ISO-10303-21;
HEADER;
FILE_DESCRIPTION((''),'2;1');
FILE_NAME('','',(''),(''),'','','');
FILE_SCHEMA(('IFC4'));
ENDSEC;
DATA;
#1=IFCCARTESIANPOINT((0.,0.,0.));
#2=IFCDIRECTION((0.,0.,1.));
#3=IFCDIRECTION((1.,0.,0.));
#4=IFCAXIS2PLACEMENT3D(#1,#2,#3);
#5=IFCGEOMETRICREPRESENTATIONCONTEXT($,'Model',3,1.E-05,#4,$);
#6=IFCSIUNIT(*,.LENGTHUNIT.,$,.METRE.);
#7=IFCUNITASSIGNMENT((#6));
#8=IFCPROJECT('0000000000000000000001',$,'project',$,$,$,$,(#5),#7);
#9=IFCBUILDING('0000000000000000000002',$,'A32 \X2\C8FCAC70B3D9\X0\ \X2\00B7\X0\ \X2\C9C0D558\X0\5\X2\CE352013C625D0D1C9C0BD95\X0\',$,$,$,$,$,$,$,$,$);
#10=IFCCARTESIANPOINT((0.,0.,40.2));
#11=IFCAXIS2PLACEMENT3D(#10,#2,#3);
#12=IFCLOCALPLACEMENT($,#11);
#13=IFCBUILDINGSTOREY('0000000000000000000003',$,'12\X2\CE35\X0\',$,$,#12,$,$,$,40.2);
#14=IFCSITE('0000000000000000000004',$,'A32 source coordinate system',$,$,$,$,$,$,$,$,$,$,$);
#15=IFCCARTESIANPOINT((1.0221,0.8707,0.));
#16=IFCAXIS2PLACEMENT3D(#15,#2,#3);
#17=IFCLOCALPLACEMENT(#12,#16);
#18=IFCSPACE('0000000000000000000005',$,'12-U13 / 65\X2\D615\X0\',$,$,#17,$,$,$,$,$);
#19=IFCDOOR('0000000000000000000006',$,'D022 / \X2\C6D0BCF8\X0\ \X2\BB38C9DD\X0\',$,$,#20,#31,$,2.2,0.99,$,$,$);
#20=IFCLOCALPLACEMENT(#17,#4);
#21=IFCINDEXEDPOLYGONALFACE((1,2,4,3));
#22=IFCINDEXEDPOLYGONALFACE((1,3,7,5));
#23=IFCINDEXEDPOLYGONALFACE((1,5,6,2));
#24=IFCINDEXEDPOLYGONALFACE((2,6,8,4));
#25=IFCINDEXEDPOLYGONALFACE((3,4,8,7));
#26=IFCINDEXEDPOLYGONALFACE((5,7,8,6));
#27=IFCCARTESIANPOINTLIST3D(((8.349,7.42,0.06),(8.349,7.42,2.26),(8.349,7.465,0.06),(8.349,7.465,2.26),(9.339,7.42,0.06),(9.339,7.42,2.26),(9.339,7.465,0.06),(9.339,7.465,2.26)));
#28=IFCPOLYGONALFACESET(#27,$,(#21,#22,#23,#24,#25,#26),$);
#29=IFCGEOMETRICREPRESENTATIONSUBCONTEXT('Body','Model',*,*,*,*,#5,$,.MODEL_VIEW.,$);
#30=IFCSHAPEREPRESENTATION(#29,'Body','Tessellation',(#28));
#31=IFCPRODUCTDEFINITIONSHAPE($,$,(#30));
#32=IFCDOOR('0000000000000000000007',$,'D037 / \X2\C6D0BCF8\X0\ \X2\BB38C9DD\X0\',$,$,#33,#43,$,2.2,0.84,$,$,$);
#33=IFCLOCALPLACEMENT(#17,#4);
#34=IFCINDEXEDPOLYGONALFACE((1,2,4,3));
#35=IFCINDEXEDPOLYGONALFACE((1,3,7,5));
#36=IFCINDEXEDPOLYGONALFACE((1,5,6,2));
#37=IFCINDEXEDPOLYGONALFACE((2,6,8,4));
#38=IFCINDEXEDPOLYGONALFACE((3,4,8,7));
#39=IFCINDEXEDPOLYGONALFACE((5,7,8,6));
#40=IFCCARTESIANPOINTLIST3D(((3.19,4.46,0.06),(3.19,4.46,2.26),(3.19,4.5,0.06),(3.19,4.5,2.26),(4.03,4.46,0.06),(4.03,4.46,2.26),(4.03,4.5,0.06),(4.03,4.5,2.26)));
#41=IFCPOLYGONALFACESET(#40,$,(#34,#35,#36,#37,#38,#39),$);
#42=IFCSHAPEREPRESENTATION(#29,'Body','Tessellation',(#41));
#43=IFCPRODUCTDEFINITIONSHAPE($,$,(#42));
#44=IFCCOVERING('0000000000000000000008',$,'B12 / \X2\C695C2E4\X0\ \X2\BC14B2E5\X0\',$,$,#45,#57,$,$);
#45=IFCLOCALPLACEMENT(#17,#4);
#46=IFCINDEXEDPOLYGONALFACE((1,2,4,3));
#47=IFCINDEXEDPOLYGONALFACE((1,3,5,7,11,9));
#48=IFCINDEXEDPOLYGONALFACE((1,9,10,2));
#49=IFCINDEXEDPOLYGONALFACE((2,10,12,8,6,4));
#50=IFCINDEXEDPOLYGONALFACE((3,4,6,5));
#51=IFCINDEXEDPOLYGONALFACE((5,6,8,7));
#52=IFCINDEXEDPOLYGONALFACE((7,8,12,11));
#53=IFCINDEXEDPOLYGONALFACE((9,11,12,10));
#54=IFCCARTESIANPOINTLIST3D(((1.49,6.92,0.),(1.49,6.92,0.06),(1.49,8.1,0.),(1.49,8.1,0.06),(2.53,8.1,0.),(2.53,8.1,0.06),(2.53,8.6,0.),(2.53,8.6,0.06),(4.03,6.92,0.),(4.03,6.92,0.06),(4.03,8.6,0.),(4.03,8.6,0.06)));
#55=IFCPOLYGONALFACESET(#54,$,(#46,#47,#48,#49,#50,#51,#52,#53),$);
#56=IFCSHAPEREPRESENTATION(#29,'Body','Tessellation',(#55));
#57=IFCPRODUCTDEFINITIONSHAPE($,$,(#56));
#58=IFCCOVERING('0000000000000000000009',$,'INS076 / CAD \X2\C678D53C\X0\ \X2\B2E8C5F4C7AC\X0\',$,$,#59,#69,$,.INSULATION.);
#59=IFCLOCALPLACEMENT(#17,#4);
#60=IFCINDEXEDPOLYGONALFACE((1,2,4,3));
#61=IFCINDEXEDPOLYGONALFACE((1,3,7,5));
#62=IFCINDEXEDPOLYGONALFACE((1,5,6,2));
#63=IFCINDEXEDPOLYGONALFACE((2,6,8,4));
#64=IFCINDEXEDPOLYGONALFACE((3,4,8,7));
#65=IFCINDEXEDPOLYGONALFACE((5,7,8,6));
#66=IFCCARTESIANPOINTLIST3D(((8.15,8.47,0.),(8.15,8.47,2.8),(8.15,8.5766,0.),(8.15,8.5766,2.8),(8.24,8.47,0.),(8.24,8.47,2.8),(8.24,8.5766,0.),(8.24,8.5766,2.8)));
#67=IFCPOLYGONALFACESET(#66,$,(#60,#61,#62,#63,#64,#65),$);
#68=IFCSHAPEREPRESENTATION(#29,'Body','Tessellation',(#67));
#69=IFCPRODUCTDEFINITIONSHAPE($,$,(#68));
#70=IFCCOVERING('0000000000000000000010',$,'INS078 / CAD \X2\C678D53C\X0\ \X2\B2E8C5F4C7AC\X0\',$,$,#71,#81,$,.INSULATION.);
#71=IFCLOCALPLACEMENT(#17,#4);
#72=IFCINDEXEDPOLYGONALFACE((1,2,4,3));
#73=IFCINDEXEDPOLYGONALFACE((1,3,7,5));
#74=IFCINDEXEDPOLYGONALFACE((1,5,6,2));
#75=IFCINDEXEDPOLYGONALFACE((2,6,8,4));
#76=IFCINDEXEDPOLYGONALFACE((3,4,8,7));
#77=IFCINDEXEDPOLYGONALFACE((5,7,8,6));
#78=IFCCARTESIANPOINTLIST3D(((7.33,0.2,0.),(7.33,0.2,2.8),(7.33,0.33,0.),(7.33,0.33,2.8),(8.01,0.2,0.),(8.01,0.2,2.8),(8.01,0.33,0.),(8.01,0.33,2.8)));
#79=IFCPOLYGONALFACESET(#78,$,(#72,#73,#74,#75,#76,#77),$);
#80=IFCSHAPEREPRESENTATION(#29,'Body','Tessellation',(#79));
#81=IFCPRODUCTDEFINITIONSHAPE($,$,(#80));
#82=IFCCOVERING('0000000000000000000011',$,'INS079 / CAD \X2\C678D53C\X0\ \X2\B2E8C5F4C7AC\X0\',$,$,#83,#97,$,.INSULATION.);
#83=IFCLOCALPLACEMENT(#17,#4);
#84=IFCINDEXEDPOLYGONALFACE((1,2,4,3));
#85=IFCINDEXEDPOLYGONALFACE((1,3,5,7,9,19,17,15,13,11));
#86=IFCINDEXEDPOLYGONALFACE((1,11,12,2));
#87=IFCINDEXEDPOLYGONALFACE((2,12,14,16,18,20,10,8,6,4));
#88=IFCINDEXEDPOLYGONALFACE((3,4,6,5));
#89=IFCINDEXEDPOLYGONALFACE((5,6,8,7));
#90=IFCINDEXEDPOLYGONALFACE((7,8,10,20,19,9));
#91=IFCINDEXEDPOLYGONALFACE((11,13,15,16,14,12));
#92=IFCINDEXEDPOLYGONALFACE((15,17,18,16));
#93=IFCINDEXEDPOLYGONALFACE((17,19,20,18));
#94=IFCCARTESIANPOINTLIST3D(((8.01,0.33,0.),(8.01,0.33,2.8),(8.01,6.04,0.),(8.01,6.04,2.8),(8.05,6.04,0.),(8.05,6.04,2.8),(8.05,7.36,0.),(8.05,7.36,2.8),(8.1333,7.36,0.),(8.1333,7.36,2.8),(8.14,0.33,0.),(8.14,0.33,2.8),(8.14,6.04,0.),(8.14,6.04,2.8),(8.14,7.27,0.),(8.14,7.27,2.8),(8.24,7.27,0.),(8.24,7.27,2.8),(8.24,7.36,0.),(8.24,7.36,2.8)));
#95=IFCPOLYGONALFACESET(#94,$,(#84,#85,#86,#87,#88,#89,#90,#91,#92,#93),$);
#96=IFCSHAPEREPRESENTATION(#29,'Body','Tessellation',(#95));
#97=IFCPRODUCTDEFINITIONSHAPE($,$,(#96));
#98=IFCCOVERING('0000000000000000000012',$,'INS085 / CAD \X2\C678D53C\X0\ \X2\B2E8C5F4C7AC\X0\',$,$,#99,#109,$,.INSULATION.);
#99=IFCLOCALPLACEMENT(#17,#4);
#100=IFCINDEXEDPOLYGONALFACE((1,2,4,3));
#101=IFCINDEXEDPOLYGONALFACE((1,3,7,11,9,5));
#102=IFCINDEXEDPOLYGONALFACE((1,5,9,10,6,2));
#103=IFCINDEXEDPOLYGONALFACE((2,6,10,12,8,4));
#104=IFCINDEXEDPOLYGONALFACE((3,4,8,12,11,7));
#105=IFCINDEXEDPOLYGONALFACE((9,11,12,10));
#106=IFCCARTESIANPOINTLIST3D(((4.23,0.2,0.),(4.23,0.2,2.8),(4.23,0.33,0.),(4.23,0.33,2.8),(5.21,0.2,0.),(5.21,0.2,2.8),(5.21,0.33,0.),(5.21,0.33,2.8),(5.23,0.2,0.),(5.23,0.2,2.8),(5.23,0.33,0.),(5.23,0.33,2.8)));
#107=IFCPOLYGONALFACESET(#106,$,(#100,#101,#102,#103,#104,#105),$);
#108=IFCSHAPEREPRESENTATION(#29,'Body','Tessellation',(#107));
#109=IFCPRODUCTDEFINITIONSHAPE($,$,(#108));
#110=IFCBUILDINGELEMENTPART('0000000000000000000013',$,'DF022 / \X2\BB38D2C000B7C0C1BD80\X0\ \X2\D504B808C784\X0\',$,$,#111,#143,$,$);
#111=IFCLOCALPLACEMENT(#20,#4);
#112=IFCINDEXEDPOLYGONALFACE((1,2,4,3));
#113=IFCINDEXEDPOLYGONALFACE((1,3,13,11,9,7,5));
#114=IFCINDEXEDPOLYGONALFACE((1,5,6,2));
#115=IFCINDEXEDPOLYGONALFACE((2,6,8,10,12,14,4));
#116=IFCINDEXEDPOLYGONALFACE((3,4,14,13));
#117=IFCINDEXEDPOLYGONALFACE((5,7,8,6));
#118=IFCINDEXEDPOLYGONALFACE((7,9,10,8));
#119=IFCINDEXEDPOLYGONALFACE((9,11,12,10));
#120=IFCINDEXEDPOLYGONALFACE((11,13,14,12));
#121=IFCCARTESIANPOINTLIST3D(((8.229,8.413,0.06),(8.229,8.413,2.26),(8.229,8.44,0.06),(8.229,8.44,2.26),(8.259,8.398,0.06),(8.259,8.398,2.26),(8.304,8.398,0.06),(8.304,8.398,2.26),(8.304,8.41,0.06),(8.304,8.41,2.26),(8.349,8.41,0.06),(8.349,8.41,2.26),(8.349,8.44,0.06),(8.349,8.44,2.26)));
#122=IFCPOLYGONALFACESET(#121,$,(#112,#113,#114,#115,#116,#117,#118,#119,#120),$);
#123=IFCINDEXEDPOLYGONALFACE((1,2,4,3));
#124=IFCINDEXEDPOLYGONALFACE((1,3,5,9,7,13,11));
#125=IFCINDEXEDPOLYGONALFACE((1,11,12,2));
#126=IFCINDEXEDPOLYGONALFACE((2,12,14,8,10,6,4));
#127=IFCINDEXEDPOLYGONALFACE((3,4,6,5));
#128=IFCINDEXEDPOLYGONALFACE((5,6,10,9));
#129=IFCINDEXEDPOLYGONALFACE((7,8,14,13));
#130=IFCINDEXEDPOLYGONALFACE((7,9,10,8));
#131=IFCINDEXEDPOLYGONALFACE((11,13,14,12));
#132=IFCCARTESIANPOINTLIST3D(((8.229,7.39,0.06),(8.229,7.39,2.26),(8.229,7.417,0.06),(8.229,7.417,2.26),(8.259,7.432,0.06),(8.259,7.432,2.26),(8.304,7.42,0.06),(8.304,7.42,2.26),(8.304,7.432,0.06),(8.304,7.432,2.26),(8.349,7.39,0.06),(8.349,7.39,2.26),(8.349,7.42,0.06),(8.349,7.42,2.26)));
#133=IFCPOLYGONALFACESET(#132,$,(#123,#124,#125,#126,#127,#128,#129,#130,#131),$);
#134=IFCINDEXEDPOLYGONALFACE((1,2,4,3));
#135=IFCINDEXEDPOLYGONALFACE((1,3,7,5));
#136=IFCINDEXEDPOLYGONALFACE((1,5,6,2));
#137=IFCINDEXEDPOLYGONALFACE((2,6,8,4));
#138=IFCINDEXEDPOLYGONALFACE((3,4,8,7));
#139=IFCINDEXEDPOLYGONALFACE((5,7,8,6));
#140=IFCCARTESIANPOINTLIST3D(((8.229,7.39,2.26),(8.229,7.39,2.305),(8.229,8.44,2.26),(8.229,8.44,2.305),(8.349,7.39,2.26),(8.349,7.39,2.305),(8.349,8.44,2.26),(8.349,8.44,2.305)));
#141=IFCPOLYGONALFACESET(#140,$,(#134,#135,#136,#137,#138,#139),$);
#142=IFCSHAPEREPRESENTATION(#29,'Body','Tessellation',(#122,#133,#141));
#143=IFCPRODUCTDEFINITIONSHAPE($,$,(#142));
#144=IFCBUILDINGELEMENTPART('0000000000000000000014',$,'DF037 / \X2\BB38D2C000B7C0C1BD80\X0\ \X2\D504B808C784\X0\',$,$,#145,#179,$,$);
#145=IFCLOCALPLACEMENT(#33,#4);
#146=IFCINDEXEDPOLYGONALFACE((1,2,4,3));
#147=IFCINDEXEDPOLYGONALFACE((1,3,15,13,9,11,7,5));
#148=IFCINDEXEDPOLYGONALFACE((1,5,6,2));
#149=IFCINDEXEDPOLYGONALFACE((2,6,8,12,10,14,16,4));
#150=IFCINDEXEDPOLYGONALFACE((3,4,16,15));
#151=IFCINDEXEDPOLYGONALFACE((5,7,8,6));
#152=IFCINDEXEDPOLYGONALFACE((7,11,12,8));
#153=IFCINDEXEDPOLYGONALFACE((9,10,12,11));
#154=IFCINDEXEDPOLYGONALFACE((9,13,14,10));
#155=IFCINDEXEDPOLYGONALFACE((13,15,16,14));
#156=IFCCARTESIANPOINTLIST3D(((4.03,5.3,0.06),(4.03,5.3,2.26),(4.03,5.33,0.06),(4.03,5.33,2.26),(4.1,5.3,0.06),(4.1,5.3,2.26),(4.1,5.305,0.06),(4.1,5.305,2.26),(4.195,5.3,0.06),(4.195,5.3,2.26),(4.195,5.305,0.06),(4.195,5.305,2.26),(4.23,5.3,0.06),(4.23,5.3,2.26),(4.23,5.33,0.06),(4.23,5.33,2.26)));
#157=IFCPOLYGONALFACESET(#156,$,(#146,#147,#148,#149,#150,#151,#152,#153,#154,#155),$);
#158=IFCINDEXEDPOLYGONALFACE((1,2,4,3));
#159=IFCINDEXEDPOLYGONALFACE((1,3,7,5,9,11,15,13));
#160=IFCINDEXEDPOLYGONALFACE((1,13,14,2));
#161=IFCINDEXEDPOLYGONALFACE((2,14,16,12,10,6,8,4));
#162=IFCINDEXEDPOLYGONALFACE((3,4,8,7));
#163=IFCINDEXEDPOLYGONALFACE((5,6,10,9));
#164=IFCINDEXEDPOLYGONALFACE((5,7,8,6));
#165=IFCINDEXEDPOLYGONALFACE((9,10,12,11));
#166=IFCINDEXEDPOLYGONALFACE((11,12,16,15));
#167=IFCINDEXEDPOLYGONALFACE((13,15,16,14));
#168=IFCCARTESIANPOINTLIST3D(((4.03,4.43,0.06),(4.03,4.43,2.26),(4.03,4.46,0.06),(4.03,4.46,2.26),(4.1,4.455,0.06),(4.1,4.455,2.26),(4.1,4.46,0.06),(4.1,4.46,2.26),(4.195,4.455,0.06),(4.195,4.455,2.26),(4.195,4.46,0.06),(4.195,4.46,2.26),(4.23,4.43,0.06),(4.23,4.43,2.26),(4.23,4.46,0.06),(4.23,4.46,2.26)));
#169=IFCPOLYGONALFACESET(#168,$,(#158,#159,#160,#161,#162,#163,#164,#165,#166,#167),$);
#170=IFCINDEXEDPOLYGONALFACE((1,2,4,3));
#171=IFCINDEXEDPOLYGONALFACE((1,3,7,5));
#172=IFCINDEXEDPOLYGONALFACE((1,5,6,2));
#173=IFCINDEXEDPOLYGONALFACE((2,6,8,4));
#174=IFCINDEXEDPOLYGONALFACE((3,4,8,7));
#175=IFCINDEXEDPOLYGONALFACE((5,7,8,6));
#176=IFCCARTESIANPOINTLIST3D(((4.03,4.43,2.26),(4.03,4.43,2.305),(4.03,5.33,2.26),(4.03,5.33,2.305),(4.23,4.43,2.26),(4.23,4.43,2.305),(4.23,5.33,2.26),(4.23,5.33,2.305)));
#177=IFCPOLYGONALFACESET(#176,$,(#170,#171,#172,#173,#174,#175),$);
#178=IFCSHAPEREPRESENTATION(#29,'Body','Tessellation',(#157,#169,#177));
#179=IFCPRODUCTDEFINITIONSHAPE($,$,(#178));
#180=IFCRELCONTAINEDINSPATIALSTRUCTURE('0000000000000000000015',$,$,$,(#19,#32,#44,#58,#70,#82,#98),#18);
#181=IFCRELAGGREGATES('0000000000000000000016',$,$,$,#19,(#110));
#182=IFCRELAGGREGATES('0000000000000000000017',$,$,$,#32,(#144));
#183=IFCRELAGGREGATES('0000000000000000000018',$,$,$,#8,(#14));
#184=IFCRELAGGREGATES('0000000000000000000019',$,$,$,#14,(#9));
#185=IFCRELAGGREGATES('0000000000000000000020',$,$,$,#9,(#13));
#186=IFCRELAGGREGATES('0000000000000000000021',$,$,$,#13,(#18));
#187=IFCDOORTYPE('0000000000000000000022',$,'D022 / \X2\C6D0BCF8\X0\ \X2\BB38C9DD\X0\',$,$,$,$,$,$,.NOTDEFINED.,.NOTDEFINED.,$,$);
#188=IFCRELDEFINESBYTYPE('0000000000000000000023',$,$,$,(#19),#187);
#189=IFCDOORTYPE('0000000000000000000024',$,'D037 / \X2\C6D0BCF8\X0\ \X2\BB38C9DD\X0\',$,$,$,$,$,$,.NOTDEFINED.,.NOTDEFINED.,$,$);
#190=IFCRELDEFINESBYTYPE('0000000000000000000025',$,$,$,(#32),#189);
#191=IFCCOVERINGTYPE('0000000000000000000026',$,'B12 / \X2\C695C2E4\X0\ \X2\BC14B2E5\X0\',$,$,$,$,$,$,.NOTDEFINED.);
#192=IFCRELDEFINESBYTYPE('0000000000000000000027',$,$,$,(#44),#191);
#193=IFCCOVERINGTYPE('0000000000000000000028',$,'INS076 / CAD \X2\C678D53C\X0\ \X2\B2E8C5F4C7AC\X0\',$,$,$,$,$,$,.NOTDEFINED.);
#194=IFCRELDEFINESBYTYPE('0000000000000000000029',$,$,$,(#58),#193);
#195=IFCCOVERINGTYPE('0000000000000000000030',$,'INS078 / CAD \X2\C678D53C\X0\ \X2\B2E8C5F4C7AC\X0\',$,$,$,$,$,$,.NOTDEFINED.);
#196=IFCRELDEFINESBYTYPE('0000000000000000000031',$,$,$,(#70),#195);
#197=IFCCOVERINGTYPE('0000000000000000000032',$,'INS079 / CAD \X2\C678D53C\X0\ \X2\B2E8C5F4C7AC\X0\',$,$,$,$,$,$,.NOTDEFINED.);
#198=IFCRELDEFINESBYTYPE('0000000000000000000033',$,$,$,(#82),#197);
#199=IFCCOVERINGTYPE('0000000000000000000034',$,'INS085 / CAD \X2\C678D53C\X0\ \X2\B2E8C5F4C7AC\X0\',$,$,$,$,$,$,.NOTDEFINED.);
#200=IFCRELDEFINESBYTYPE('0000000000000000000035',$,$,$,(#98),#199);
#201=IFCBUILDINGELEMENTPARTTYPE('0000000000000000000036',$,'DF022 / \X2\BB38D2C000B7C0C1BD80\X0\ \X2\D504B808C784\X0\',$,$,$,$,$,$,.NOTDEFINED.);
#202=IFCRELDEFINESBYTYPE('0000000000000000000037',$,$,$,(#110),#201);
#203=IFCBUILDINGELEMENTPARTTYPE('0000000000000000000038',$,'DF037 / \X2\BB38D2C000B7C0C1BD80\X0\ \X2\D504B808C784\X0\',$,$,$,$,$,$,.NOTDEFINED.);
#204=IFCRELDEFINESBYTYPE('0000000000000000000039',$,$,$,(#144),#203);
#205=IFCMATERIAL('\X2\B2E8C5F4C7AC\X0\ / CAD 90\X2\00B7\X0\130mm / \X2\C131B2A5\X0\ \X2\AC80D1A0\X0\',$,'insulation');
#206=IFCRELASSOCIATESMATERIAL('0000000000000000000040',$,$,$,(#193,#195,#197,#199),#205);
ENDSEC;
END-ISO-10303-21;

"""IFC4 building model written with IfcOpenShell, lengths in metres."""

from ifc_helpers import new_model, si_unit, frame, origin, origin_with_axes, place, context, subcontext, project, spatial, polyline, outline, extrude, source, transform, mapped, material, type_object, type_shapes, element, aggregate, save


model = new_model("IFC4")

# Units and contexts
model_context = context("Model", 3, precision=1e-05, world=origin_with_axes())
body_context = subcontext(model_context, "Body", "Model", "MODEL_VIEW")
ifc_project = project(units=[si_unit("LENGTHUNIT", "METRE")], contexts=[model_context])

# Site, building, storey
site = spatial("IfcSite", under=ifc_project, Name="A32 source coordinate system")
building = spatial("IfcBuilding", under=site, Name="A32 주거동 · 지하5층–옥탑지붕")
storey_placement = place(None, frame((0.0, 0.0, 40.2), z_axis=(0.0, 0.0, 1.0), x_axis=(1.0, 0.0, 0.0)))
storey = spatial("IfcBuildingStorey", under=building, at=storey_placement, Name="12층", Elevation=40.2)

# Shared definitions
space_placement = place(storey_placement, frame((1.0221, 0.8707, 0.0), z_axis=(0.0, 0.0, 1.0), x_axis=(1.0, 0.0, 0.0)))
space = spatial("IfcSpace", under=storey, at=space_placement, Name="12-U13 / 65형")

# Doors
door_type_1 = type_object("IfcDoorType", Name="D022 / 원본 문짝", OperationType="NOTDEFINED", PredefinedType="NOTDEFINED")
shared_shape_1 = source(origin(), body_context, "Body", "SweptSolid", [
    extrude(outline(polyline([(9.339, 7.465), (9.339, 7.42), (8.349, 7.42), (8.349, 7.465), (9.339, 7.465)])), frame((0.0, 0.0, 0.06)), (0.0, 0.0, 1.0), 2.2),
])
type_shapes(door_type_1, [shared_shape_1])
door_1_placement = place(space_placement, origin_with_axes())
door_1 = element("IfcDoor", 1, at=door_1_placement, inside=space, type_object=door_type_1, Name="D022 / 원본 문짝", OverallHeight=2.2, OverallWidth=0.99, context=body_context, shape_type="MappedRepresentation", body=[
    mapped(shared_shape_1, transform((0.0, 0.0, 0.0), scale=1.0)),
])
door_type_2 = type_object("IfcDoorType", Name="D037 / 원본 문짝", OperationType="NOTDEFINED", PredefinedType="NOTDEFINED")
shared_shape_2 = source(origin(), body_context, "Body", "SweptSolid", [
    extrude(outline(polyline([(4.03, 4.46), (3.19, 4.46), (3.19, 4.5), (4.03, 4.5), (4.03, 4.46)])), frame((0.0, 0.0, 0.06)), (0.0, 0.0, 1.0), 2.2),
])
type_shapes(door_type_2, [shared_shape_2])
door_2_placement = place(space_placement, origin_with_axes())
door_2 = element("IfcDoor", 2, at=door_2_placement, inside=space, type_object=door_type_2, Name="D037 / 원본 문짝", OverallHeight=2.2, OverallWidth=0.84, context=body_context, shape_type="MappedRepresentation", body=[
    mapped(shared_shape_2, transform((0.0, 0.0, 0.0), scale=1.0)),
])

# Coverings
covering_type_1 = type_object("IfcCoveringType", Name="B12 / 욕실 바닥", PredefinedType="NOTDEFINED")
shared_shape_3 = source(origin(), body_context, "Body", "SweptSolid", [
    extrude(outline(polyline([(2.53, 8.6), (4.03, 8.6), (4.03, 6.92), (1.49, 6.92), (1.49, 8.1), (2.53, 8.1), (2.53, 8.6)])), origin(), (0.0, 0.0, 1.0), 0.06),
])
type_shapes(covering_type_1, [shared_shape_3])
covering_1_placement = place(space_placement, origin_with_axes())
element("IfcCovering", 3, at=covering_1_placement, inside=space, type_object=covering_type_1, Name="B12 / 욕실 바닥", context=body_context, shape_type="MappedRepresentation", body=[
    mapped(shared_shape_3, transform((0.0, 0.0, 0.0), scale=1.0)),
])
ifc_material = material(Name="단열재 / CAD 90·130mm / 성능 검토", Category="insulation")
covering_type_2 = type_object("IfcCoveringType", Name="INS076 / CAD 외피 단열재", PredefinedType="NOTDEFINED", material=ifc_material)
shared_shape_4 = source(origin(), body_context, "Body", "SweptSolid", [
    extrude(outline(polyline([(8.24, 8.5766), (8.24, 8.47), (8.15, 8.47), (8.15, 8.5766), (8.24, 8.5766)])), origin(), (0.0, 0.0, 1.0), 2.8),
])
type_shapes(covering_type_2, [shared_shape_4])
covering_2_placement = place(space_placement, origin_with_axes())
element("IfcCovering", 4, at=covering_2_placement, inside=space, type_object=covering_type_2, Name="INS076 / CAD 외피 단열재", PredefinedType="INSULATION", context=body_context, shape_type="MappedRepresentation", body=[
    mapped(shared_shape_4, transform((0.0, 0.0, 0.0), scale=1.0)),
])
covering_type_3 = type_object("IfcCoveringType", Name="INS078 / CAD 외피 단열재", PredefinedType="NOTDEFINED", material=ifc_material)
shared_shape_5 = source(origin(), body_context, "Body", "SweptSolid", [
    extrude(outline(polyline([(8.01, 0.2), (7.33, 0.2), (7.33, 0.33), (8.01, 0.33), (8.01, 0.2)])), origin(), (0.0, 0.0, 1.0), 2.8),
])
type_shapes(covering_type_3, [shared_shape_5])
covering_3_placement = place(space_placement, origin_with_axes())
element("IfcCovering", 5, at=covering_3_placement, inside=space, type_object=covering_type_3, Name="INS078 / CAD 외피 단열재", PredefinedType="INSULATION", context=body_context, shape_type="MappedRepresentation", body=[
    mapped(shared_shape_5, transform((0.0, 0.0, 0.0), scale=1.0)),
])
covering_type_4 = type_object("IfcCoveringType", Name="INS079 / CAD 외피 단열재", PredefinedType="NOTDEFINED", material=ifc_material)
shared_shape_6 = source(origin(), body_context, "Body", "SweptSolid", [
    extrude(outline(polyline([(8.24, 7.27), (8.14, 7.27), (8.14, 6.04), (8.14, 0.33), (8.01, 0.33), (8.01, 6.04), (8.05, 6.04), (8.05, 7.36), (8.1333, 7.36), (8.24, 7.36), (8.24, 7.27)])), origin(), (0.0, 0.0, 1.0), 2.8),
])
type_shapes(covering_type_4, [shared_shape_6])
covering_4_placement = place(space_placement, origin_with_axes())
element("IfcCovering", 6, at=covering_4_placement, inside=space, type_object=covering_type_4, Name="INS079 / CAD 외피 단열재", PredefinedType="INSULATION", context=body_context, shape_type="MappedRepresentation", body=[
    mapped(shared_shape_6, transform((0.0, 0.0, 0.0), scale=1.0)),
])
covering_type_5 = type_object("IfcCoveringType", Name="INS085 / CAD 외피 단열재", PredefinedType="NOTDEFINED", material=ifc_material)
shared_shape_7 = source(origin(), body_context, "Body", "SweptSolid", [
    extrude(outline(polyline([(4.23, 0.2), (4.23, 0.33), (5.21, 0.33), (5.23, 0.33), (5.23, 0.2), (5.21, 0.2), (4.23, 0.2)])), origin(), (0.0, 0.0, 1.0), 2.8),
])
type_shapes(covering_type_5, [shared_shape_7])
covering_5_placement = place(space_placement, origin_with_axes())
element("IfcCovering", 7, at=covering_5_placement, inside=space, type_object=covering_type_5, Name="INS085 / CAD 외피 단열재", PredefinedType="INSULATION", context=body_context, shape_type="MappedRepresentation", body=[
    mapped(shared_shape_7, transform((0.0, 0.0, 0.0), scale=1.0)),
])

# Building element parts
building_element_part_type_1 = type_object("IfcBuildingElementPartType", Name="DF022 / 문틀·상부 프레임", PredefinedType="NOTDEFINED")
shared_shape_8 = source(origin(), body_context, "Body", "SweptSolid", [
    extrude(outline(polyline([(8.349, 8.41), (8.304, 8.41), (8.304, 8.398), (8.259, 8.398), (8.229, 8.413), (8.229, 8.44), (8.349, 8.44), (8.349, 8.41)])), frame((0.0, 0.0, 0.06)), (0.0, 0.0, 1.0), 2.2),
    extrude(outline(polyline([(8.229, 7.39), (8.229, 7.417), (8.259, 7.432), (8.304, 7.432), (8.304, 7.42), (8.349, 7.42), (8.349, 7.39), (8.229, 7.39)])), frame((0.0, 0.0, 0.06)), (0.0, 0.0, 1.0), 2.2),
    extrude(outline(polyline([(8.229, 7.39), (8.229, 8.44), (8.349, 8.44), (8.349, 7.39), (8.229, 7.39)])), frame((0.0, 0.0, 2.26)), (0.0, 0.0, 1.0), 0.045),
])
type_shapes(building_element_part_type_1, [shared_shape_8])
building_element_part_1_placement = place(door_1_placement, origin_with_axes())
building_element_part_1 = element("IfcBuildingElementPart", 8, at=building_element_part_1_placement, type_object=building_element_part_type_1, Name="DF022 / 문틀·상부 프레임", context=body_context, shape_type="MappedRepresentation", body=[
    mapped(shared_shape_8, transform((0.0, 0.0, 0.0), scale=1.0)),
])
aggregate(door_1, [building_element_part_1])
building_element_part_type_2 = type_object("IfcBuildingElementPartType", Name="DF037 / 문틀·상부 프레임", PredefinedType="NOTDEFINED")
shared_shape_9 = source(origin(), body_context, "Body", "SweptSolid", [
    extrude(outline(polyline([(4.23, 5.33), (4.23, 5.3), (4.195, 5.3), (4.195, 5.305), (4.1, 5.305), (4.1, 5.3), (4.03, 5.3), (4.03, 5.33), (4.23, 5.33)])), frame((0.0, 0.0, 0.06)), (0.0, 0.0, 1.0), 2.2),
    extrude(outline(polyline([(4.03, 4.46), (4.1, 4.46), (4.1, 4.455), (4.195, 4.455), (4.195, 4.46), (4.23, 4.46), (4.23, 4.43), (4.03, 4.43), (4.03, 4.46)])), frame((0.0, 0.0, 0.06)), (0.0, 0.0, 1.0), 2.2),
    extrude(outline(polyline([(4.03, 4.43), (4.03, 5.33), (4.23, 5.33), (4.23, 4.43), (4.03, 4.43)])), frame((0.0, 0.0, 2.26)), (0.0, 0.0, 1.0), 0.045),
])
type_shapes(building_element_part_type_2, [shared_shape_9])
building_element_part_2_placement = place(door_2_placement, origin_with_axes())
building_element_part_2 = element("IfcBuildingElementPart", 9, at=building_element_part_2_placement, type_object=building_element_part_type_2, Name="DF037 / 문틀·상부 프레임", context=body_context, shape_type="MappedRepresentation", body=[
    mapped(shared_shape_9, transform((0.0, 0.0, 0.0), scale=1.0)),
])
aggregate(door_2, [building_element_part_2])

save(model, "model.ifc")
